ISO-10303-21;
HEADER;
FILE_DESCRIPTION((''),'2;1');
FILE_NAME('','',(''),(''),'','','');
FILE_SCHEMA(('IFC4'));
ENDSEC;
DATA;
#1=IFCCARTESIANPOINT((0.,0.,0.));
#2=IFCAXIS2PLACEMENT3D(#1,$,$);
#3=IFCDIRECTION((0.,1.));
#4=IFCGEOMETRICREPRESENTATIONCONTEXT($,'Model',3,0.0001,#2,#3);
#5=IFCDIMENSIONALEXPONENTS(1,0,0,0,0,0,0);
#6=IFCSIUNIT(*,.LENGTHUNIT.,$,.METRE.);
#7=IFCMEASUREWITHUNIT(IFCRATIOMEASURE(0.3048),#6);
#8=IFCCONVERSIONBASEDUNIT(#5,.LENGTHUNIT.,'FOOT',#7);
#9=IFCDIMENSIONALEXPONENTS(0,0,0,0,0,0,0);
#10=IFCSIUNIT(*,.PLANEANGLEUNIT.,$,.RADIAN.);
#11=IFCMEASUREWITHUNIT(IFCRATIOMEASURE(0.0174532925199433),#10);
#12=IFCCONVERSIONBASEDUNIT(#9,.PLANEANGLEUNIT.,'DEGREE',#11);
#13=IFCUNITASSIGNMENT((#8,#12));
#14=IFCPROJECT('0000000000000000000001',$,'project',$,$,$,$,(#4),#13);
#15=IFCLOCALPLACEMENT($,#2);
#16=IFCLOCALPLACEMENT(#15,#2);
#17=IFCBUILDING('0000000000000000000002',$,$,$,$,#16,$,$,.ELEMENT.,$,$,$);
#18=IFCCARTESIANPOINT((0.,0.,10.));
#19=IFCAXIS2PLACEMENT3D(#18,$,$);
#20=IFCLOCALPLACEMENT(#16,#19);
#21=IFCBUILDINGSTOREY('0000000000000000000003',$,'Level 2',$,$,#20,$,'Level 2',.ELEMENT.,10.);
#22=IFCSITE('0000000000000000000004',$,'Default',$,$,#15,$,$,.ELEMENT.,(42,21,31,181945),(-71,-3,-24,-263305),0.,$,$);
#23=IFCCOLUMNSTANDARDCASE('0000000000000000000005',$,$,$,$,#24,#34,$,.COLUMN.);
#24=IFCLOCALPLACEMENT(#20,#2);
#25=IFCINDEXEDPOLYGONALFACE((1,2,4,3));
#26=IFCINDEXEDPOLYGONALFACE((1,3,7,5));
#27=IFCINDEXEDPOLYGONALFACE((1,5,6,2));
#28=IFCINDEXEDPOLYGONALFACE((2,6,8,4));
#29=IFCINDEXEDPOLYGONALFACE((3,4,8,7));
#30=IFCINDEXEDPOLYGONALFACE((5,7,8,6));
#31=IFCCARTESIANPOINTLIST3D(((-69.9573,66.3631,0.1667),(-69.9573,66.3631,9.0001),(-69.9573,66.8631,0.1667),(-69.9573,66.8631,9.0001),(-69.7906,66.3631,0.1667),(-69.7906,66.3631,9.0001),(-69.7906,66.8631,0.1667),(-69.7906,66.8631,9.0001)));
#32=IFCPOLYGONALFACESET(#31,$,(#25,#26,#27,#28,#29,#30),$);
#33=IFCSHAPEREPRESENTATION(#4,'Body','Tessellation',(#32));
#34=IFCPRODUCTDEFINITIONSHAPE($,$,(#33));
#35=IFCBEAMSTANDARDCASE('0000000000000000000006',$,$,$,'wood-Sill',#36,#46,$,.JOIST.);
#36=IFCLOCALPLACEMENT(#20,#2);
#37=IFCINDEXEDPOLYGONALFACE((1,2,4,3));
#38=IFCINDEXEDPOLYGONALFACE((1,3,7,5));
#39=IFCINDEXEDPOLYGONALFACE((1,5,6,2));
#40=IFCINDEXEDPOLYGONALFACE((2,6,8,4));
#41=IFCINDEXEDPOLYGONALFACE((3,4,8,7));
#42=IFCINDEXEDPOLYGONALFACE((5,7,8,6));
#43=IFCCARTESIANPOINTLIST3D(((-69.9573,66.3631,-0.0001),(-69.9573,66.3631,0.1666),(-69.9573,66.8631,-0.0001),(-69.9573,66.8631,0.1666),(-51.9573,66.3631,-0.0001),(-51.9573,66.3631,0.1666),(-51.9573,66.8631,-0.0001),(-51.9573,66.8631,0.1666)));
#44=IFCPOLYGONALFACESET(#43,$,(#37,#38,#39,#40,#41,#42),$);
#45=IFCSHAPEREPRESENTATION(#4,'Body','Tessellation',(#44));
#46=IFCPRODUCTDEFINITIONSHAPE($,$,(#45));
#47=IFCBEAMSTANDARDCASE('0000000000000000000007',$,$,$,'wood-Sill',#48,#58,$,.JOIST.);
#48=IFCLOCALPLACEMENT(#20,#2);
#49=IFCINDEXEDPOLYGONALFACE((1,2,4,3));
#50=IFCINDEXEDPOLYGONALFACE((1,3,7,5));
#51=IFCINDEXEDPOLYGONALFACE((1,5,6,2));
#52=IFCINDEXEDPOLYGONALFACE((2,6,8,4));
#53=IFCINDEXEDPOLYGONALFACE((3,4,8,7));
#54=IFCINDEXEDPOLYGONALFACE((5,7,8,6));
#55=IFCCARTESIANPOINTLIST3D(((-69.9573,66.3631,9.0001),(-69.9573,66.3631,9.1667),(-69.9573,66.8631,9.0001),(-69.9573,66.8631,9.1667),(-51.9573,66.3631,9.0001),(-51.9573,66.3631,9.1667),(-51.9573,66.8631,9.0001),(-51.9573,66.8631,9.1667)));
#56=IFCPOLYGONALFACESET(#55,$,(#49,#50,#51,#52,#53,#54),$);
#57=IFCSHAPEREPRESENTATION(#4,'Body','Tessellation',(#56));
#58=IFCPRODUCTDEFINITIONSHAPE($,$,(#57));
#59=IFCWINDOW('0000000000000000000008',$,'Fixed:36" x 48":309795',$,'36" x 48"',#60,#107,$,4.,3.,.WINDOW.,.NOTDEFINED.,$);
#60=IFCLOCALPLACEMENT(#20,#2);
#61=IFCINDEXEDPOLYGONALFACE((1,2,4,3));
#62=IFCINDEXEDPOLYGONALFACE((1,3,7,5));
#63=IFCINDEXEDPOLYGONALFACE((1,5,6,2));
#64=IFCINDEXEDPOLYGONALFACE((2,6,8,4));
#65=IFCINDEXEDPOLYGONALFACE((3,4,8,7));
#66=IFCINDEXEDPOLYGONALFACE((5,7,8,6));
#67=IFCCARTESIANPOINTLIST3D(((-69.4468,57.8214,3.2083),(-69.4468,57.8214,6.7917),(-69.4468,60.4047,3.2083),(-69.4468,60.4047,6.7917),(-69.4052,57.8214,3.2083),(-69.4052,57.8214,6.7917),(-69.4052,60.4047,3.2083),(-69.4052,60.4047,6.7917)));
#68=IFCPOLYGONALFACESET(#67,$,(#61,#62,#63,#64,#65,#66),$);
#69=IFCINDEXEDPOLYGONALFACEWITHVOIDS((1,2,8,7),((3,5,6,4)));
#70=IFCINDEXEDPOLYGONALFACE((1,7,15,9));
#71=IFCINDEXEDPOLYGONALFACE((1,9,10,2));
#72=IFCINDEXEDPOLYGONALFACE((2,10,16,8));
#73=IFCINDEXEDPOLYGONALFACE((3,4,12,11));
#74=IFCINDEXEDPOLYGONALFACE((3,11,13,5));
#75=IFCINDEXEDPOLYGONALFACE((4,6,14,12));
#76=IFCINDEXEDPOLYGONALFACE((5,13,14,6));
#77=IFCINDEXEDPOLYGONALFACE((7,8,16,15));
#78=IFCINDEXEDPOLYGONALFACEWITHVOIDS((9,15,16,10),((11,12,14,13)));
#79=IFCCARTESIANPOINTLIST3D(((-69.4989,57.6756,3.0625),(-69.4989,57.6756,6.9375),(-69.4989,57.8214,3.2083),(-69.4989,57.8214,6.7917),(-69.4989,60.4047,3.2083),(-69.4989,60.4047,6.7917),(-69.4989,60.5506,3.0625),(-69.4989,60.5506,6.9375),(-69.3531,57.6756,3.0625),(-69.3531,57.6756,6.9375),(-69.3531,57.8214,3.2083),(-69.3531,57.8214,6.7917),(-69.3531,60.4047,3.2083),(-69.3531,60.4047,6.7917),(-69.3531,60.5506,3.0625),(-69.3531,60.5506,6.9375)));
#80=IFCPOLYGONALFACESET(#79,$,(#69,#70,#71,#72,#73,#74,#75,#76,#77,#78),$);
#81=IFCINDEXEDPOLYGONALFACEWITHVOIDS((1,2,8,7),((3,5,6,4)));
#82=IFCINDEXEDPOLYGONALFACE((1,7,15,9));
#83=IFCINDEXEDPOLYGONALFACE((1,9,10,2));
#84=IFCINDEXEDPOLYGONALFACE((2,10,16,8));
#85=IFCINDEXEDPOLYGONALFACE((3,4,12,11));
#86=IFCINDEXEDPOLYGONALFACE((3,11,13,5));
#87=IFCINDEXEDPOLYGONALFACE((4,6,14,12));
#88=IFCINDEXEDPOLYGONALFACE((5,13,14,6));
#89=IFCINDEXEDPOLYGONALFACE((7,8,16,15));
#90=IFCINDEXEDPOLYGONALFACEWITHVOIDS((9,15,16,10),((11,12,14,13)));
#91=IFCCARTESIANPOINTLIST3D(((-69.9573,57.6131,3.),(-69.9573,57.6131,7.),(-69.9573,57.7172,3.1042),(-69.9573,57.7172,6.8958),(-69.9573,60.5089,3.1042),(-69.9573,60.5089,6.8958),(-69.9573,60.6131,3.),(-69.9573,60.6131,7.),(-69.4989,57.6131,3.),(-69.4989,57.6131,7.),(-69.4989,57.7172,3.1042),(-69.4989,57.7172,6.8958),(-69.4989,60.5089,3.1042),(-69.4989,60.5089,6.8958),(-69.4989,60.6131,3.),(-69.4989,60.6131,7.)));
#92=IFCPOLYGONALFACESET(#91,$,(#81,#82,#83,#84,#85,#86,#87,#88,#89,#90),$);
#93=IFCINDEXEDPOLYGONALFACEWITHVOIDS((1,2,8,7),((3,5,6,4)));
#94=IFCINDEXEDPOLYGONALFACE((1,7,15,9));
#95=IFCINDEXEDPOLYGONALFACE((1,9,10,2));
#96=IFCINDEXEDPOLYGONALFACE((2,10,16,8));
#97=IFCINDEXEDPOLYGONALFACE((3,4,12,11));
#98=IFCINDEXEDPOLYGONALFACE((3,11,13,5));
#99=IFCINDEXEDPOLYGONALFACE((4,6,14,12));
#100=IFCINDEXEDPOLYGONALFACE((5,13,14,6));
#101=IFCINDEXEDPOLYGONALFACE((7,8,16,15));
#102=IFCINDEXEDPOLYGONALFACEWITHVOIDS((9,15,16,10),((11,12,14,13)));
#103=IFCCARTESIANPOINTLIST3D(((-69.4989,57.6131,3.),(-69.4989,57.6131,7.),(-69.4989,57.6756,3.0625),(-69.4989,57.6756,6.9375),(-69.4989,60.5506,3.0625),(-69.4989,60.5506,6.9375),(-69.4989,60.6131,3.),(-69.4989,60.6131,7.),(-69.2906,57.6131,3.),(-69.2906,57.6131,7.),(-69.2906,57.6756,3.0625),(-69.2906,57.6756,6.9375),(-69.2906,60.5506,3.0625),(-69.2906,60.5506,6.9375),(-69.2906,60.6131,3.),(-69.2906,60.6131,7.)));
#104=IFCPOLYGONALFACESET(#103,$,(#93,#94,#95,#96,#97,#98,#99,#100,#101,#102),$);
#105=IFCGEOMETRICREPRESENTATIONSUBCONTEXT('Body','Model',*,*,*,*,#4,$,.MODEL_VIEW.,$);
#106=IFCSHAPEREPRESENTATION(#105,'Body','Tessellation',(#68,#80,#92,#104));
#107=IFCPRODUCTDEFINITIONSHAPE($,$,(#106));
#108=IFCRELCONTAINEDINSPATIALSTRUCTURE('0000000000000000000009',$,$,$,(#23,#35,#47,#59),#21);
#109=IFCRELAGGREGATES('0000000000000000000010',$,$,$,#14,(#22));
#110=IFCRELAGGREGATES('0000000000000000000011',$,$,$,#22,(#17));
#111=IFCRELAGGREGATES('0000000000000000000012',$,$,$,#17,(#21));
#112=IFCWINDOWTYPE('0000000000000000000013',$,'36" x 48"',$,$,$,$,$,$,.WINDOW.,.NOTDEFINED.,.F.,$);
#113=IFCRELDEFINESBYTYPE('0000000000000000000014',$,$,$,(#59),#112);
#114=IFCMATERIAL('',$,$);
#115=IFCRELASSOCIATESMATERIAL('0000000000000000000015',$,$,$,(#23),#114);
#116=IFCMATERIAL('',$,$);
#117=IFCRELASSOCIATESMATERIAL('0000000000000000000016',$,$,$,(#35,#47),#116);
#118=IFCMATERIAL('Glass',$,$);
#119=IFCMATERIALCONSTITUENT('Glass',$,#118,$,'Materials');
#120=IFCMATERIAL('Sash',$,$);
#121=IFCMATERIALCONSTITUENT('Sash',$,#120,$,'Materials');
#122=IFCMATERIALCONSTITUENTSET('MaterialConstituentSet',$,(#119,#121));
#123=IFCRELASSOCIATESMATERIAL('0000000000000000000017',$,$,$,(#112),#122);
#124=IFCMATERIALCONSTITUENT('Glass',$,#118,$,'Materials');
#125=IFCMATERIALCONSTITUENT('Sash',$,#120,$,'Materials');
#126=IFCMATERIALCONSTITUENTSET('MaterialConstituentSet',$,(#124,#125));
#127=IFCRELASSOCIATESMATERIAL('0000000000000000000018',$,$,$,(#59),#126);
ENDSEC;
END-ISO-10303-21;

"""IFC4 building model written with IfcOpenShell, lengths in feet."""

from ifc_helpers import new_model, entity, si_unit, converted_unit, direction, frame, frame_2d, origin, origin_with_axes, place, context, subcontext, project, spatial, polyline, rectangle, outline, extrude, source, transform, mapped, material, constituent, constituent_set, type_object, type_shapes, element, save


model = new_model("IFC4")

# Units and contexts
model_context = context("Model", 3, precision=0.0001, world=origin(), true_north=direction((0.0, 1.0)))
body_context = subcontext(model_context, "Body", "Model", "MODEL_VIEW")
ifc_project = project(units=[converted_unit("LENGTHUNIT", "FOOT", entity("IfcRatioMeasure", 0.3048), si_unit("LENGTHUNIT", "METRE"), dimensions=[1, 0, 0, 0, 0, 0, 0]), converted_unit("PLANEANGLEUNIT", "DEGREE", entity("IfcRatioMeasure", 0.0174532925199433), si_unit("PLANEANGLEUNIT", "RADIAN"), dimensions=[0, 0, 0, 0, 0, 0, 0])], contexts=[model_context])

# Site, building, storey
site_placement = place(None, origin())
site = spatial("IfcSite", under=ifc_project, at=site_placement, Name="Default", CompositionType="ELEMENT", RefLatitude=(42, 21, 31, 181945), RefLongitude=(-71, -3, -24, -263305), RefElevation=0.0)
building_placement = place(site_placement, origin())
building = spatial("IfcBuilding", under=site, at=building_placement, CompositionType="ELEMENT")
storey_placement = place(building_placement, frame((0.0, 0.0, 10.0)))
storey = spatial("IfcBuildingStorey", under=building, at=storey_placement, Name="Level 2", LongName="Level 2", CompositionType="ELEMENT", Elevation=10.0)

# Column
ifc_material_1 = material(Name="")
placement_1 = place(storey_placement, frame((-69.9573, 66.6131, 0.0)))
for number, where, z_axis, x_axis in (
    (1, (0.0833, 0.0, 0.1667), (0.0, 0.0, 1.0), (1.0, 0.0, 0.0)),
):
    element("IfcColumnStandardCase", number, at=place(placement_1, frame(where, z_axis=z_axis, x_axis=x_axis)), inside=storey, material=ifc_material_1, PredefinedType="COLUMN", context=model_context, shape_type="SweptSolid", body=[
        extrude(rectangle(XDim=0.1667, YDim=0.5), origin(), (0.0, 0.0, 1.0), 8.8334),
    ])
placement_2 = place(storey_placement, frame((-69.6239, 19.7797, 0.0), z_axis=(0.0, 0.0, 1.0), x_axis=(0.0, 1.0, 0.0)))

# Beams
ifc_material_2 = material(Name="")
for number, where, z_axis, x_axis in (
    (2, (0.0, 0.0, 0.0833), (1.0, 0.0, 0.0), (0.0, 0.0, 1.0)),
    (3, (0.0, 0.0, 9.0834), (1.0, 0.0, 0.0), (0.0, 0.0, 1.0)),
):
    element("IfcBeamStandardCase", number, at=place(placement_1, frame(where, z_axis=z_axis, x_axis=x_axis)), inside=storey, material=ifc_material_2, ObjectType="wood-Sill", PredefinedType="JOIST", context=model_context, shape_type="SweptSolid", body=[
        extrude(rectangle(XDim=0.1667, YDim=0.5), origin_with_axes(), (0.0, 0.0, 1.0), 18.0),
    ])

# Window
ifc_material_3 = material(Name="Glass")
ifc_constituent_1 = constituent(ifc_material_3, Name="Glass", Category="Materials")
ifc_material_4 = material(Name="Sash")
ifc_constituent_2 = constituent(ifc_material_4, Name="Sash", Category="Materials")
ifc_constituent_set_1 = constituent_set(constituents=[ifc_constituent_1, ifc_constituent_2], Name="MaterialConstituentSet")
ifc_constituent_3 = constituent(ifc_material_3, Name="Glass", Category="Materials")
ifc_constituent_4 = constituent(ifc_material_4, Name="Sash", Category="Materials")
ifc_constituent_set_2 = constituent_set(constituents=[ifc_constituent_3, ifc_constituent_4], Name="MaterialConstituentSet")
window_type = type_object("IfcWindowType", Name="36\" x 48\"", ParameterTakesPrecedence=False, PartitioningType="NOTDEFINED", PredefinedType="WINDOW", material=ifc_constituent_set_2)
shared_shape = source(origin(), body_context, "Body", "SweptSolid", [
    extrude(rectangle(XDim=0.0417, YDim=2.5833, at=frame_2d((0.0, 0.0), x_axis=(1.0, 0.0))), frame((1.5, 0.5312, 0.2083), z_axis=(0.0, 0.0, 1.0), x_axis=(0.0, 1.0, 0.0)), (0.0, 0.0, 1.0), 3.5833),
    extrude(outline(polyline([(-1.4375, -1.9375), (1.4375, -1.9375), (1.4375, 1.9375), (-1.4375, 1.9375), (-1.4375, -1.9375)]), holes=[polyline([(-1.2917, -1.7917), (-1.2917, 1.7917), (1.2917, 1.7917), (1.2917, -1.7917), (-1.2917, -1.7917)])]), frame((1.5, 0.4583, 2.0), z_axis=(0.0, 1.0, 0.0), x_axis=(1.0, 0.0, 0.0)), (0.0, 0.0, 1.0), 0.1458),
    extrude(outline(polyline([(-1.5, -2.0), (1.5, -2.0), (1.5, 2.0), (-1.5, 2.0), (-1.5, -2.0)]), holes=[polyline([(-1.3958, -1.8958), (-1.3958, 1.8958), (1.3958, 1.8958), (1.3958, -1.8958), (-1.3958, -1.8958)])]), frame((1.5, 0.0, 2.0), z_axis=(0.0, 1.0, 0.0), x_axis=(1.0, 0.0, 0.0)), (0.0, 0.0, 1.0), 0.4583),
    extrude(outline(polyline([(-2.0, -1.5), (2.0, -1.5), (2.0, 1.5), (-2.0, 1.5), (-2.0, -1.5)]), holes=[polyline([(-1.9375, -1.4375), (-1.9375, 1.4375), (1.9375, 1.4375), (1.9375, -1.4375), (-1.9375, -1.4375)])]), frame((1.5, 0.4583, 2.0), z_axis=(0.0, 1.0, 0.0), x_axis=(0.0, 0.0, -1.0)), (0.0, 0.0, 1.0), 0.2083),
])
type_shapes(window_type, [shared_shape])
placement_3 = place(placement_2, frame((40.8333, 0.3333, 3.0)))
window_placement = place(placement_3, frame((0.0, 0.0, 0.0), z_axis=(0.0, 0.0, 1.0), x_axis=(-1.0, 0.0, 0.0)))
element("IfcWindow", 4, at=window_placement, inside=storey, type_object=window_type, material=ifc_constituent_set_1, Name="Fixed:36\" x 48\":309795", ObjectType="36\" x 48\"", OverallHeight=4.0, OverallWidth=3.0, PartitioningType="NOTDEFINED", PredefinedType="WINDOW", context=body_context, shape_type="MappedRepresentation", body=[
    mapped(shared_shape, transform((0.0, 0.0, 0.0), scale=1.0)),
])

save(model, "model.ifc")
